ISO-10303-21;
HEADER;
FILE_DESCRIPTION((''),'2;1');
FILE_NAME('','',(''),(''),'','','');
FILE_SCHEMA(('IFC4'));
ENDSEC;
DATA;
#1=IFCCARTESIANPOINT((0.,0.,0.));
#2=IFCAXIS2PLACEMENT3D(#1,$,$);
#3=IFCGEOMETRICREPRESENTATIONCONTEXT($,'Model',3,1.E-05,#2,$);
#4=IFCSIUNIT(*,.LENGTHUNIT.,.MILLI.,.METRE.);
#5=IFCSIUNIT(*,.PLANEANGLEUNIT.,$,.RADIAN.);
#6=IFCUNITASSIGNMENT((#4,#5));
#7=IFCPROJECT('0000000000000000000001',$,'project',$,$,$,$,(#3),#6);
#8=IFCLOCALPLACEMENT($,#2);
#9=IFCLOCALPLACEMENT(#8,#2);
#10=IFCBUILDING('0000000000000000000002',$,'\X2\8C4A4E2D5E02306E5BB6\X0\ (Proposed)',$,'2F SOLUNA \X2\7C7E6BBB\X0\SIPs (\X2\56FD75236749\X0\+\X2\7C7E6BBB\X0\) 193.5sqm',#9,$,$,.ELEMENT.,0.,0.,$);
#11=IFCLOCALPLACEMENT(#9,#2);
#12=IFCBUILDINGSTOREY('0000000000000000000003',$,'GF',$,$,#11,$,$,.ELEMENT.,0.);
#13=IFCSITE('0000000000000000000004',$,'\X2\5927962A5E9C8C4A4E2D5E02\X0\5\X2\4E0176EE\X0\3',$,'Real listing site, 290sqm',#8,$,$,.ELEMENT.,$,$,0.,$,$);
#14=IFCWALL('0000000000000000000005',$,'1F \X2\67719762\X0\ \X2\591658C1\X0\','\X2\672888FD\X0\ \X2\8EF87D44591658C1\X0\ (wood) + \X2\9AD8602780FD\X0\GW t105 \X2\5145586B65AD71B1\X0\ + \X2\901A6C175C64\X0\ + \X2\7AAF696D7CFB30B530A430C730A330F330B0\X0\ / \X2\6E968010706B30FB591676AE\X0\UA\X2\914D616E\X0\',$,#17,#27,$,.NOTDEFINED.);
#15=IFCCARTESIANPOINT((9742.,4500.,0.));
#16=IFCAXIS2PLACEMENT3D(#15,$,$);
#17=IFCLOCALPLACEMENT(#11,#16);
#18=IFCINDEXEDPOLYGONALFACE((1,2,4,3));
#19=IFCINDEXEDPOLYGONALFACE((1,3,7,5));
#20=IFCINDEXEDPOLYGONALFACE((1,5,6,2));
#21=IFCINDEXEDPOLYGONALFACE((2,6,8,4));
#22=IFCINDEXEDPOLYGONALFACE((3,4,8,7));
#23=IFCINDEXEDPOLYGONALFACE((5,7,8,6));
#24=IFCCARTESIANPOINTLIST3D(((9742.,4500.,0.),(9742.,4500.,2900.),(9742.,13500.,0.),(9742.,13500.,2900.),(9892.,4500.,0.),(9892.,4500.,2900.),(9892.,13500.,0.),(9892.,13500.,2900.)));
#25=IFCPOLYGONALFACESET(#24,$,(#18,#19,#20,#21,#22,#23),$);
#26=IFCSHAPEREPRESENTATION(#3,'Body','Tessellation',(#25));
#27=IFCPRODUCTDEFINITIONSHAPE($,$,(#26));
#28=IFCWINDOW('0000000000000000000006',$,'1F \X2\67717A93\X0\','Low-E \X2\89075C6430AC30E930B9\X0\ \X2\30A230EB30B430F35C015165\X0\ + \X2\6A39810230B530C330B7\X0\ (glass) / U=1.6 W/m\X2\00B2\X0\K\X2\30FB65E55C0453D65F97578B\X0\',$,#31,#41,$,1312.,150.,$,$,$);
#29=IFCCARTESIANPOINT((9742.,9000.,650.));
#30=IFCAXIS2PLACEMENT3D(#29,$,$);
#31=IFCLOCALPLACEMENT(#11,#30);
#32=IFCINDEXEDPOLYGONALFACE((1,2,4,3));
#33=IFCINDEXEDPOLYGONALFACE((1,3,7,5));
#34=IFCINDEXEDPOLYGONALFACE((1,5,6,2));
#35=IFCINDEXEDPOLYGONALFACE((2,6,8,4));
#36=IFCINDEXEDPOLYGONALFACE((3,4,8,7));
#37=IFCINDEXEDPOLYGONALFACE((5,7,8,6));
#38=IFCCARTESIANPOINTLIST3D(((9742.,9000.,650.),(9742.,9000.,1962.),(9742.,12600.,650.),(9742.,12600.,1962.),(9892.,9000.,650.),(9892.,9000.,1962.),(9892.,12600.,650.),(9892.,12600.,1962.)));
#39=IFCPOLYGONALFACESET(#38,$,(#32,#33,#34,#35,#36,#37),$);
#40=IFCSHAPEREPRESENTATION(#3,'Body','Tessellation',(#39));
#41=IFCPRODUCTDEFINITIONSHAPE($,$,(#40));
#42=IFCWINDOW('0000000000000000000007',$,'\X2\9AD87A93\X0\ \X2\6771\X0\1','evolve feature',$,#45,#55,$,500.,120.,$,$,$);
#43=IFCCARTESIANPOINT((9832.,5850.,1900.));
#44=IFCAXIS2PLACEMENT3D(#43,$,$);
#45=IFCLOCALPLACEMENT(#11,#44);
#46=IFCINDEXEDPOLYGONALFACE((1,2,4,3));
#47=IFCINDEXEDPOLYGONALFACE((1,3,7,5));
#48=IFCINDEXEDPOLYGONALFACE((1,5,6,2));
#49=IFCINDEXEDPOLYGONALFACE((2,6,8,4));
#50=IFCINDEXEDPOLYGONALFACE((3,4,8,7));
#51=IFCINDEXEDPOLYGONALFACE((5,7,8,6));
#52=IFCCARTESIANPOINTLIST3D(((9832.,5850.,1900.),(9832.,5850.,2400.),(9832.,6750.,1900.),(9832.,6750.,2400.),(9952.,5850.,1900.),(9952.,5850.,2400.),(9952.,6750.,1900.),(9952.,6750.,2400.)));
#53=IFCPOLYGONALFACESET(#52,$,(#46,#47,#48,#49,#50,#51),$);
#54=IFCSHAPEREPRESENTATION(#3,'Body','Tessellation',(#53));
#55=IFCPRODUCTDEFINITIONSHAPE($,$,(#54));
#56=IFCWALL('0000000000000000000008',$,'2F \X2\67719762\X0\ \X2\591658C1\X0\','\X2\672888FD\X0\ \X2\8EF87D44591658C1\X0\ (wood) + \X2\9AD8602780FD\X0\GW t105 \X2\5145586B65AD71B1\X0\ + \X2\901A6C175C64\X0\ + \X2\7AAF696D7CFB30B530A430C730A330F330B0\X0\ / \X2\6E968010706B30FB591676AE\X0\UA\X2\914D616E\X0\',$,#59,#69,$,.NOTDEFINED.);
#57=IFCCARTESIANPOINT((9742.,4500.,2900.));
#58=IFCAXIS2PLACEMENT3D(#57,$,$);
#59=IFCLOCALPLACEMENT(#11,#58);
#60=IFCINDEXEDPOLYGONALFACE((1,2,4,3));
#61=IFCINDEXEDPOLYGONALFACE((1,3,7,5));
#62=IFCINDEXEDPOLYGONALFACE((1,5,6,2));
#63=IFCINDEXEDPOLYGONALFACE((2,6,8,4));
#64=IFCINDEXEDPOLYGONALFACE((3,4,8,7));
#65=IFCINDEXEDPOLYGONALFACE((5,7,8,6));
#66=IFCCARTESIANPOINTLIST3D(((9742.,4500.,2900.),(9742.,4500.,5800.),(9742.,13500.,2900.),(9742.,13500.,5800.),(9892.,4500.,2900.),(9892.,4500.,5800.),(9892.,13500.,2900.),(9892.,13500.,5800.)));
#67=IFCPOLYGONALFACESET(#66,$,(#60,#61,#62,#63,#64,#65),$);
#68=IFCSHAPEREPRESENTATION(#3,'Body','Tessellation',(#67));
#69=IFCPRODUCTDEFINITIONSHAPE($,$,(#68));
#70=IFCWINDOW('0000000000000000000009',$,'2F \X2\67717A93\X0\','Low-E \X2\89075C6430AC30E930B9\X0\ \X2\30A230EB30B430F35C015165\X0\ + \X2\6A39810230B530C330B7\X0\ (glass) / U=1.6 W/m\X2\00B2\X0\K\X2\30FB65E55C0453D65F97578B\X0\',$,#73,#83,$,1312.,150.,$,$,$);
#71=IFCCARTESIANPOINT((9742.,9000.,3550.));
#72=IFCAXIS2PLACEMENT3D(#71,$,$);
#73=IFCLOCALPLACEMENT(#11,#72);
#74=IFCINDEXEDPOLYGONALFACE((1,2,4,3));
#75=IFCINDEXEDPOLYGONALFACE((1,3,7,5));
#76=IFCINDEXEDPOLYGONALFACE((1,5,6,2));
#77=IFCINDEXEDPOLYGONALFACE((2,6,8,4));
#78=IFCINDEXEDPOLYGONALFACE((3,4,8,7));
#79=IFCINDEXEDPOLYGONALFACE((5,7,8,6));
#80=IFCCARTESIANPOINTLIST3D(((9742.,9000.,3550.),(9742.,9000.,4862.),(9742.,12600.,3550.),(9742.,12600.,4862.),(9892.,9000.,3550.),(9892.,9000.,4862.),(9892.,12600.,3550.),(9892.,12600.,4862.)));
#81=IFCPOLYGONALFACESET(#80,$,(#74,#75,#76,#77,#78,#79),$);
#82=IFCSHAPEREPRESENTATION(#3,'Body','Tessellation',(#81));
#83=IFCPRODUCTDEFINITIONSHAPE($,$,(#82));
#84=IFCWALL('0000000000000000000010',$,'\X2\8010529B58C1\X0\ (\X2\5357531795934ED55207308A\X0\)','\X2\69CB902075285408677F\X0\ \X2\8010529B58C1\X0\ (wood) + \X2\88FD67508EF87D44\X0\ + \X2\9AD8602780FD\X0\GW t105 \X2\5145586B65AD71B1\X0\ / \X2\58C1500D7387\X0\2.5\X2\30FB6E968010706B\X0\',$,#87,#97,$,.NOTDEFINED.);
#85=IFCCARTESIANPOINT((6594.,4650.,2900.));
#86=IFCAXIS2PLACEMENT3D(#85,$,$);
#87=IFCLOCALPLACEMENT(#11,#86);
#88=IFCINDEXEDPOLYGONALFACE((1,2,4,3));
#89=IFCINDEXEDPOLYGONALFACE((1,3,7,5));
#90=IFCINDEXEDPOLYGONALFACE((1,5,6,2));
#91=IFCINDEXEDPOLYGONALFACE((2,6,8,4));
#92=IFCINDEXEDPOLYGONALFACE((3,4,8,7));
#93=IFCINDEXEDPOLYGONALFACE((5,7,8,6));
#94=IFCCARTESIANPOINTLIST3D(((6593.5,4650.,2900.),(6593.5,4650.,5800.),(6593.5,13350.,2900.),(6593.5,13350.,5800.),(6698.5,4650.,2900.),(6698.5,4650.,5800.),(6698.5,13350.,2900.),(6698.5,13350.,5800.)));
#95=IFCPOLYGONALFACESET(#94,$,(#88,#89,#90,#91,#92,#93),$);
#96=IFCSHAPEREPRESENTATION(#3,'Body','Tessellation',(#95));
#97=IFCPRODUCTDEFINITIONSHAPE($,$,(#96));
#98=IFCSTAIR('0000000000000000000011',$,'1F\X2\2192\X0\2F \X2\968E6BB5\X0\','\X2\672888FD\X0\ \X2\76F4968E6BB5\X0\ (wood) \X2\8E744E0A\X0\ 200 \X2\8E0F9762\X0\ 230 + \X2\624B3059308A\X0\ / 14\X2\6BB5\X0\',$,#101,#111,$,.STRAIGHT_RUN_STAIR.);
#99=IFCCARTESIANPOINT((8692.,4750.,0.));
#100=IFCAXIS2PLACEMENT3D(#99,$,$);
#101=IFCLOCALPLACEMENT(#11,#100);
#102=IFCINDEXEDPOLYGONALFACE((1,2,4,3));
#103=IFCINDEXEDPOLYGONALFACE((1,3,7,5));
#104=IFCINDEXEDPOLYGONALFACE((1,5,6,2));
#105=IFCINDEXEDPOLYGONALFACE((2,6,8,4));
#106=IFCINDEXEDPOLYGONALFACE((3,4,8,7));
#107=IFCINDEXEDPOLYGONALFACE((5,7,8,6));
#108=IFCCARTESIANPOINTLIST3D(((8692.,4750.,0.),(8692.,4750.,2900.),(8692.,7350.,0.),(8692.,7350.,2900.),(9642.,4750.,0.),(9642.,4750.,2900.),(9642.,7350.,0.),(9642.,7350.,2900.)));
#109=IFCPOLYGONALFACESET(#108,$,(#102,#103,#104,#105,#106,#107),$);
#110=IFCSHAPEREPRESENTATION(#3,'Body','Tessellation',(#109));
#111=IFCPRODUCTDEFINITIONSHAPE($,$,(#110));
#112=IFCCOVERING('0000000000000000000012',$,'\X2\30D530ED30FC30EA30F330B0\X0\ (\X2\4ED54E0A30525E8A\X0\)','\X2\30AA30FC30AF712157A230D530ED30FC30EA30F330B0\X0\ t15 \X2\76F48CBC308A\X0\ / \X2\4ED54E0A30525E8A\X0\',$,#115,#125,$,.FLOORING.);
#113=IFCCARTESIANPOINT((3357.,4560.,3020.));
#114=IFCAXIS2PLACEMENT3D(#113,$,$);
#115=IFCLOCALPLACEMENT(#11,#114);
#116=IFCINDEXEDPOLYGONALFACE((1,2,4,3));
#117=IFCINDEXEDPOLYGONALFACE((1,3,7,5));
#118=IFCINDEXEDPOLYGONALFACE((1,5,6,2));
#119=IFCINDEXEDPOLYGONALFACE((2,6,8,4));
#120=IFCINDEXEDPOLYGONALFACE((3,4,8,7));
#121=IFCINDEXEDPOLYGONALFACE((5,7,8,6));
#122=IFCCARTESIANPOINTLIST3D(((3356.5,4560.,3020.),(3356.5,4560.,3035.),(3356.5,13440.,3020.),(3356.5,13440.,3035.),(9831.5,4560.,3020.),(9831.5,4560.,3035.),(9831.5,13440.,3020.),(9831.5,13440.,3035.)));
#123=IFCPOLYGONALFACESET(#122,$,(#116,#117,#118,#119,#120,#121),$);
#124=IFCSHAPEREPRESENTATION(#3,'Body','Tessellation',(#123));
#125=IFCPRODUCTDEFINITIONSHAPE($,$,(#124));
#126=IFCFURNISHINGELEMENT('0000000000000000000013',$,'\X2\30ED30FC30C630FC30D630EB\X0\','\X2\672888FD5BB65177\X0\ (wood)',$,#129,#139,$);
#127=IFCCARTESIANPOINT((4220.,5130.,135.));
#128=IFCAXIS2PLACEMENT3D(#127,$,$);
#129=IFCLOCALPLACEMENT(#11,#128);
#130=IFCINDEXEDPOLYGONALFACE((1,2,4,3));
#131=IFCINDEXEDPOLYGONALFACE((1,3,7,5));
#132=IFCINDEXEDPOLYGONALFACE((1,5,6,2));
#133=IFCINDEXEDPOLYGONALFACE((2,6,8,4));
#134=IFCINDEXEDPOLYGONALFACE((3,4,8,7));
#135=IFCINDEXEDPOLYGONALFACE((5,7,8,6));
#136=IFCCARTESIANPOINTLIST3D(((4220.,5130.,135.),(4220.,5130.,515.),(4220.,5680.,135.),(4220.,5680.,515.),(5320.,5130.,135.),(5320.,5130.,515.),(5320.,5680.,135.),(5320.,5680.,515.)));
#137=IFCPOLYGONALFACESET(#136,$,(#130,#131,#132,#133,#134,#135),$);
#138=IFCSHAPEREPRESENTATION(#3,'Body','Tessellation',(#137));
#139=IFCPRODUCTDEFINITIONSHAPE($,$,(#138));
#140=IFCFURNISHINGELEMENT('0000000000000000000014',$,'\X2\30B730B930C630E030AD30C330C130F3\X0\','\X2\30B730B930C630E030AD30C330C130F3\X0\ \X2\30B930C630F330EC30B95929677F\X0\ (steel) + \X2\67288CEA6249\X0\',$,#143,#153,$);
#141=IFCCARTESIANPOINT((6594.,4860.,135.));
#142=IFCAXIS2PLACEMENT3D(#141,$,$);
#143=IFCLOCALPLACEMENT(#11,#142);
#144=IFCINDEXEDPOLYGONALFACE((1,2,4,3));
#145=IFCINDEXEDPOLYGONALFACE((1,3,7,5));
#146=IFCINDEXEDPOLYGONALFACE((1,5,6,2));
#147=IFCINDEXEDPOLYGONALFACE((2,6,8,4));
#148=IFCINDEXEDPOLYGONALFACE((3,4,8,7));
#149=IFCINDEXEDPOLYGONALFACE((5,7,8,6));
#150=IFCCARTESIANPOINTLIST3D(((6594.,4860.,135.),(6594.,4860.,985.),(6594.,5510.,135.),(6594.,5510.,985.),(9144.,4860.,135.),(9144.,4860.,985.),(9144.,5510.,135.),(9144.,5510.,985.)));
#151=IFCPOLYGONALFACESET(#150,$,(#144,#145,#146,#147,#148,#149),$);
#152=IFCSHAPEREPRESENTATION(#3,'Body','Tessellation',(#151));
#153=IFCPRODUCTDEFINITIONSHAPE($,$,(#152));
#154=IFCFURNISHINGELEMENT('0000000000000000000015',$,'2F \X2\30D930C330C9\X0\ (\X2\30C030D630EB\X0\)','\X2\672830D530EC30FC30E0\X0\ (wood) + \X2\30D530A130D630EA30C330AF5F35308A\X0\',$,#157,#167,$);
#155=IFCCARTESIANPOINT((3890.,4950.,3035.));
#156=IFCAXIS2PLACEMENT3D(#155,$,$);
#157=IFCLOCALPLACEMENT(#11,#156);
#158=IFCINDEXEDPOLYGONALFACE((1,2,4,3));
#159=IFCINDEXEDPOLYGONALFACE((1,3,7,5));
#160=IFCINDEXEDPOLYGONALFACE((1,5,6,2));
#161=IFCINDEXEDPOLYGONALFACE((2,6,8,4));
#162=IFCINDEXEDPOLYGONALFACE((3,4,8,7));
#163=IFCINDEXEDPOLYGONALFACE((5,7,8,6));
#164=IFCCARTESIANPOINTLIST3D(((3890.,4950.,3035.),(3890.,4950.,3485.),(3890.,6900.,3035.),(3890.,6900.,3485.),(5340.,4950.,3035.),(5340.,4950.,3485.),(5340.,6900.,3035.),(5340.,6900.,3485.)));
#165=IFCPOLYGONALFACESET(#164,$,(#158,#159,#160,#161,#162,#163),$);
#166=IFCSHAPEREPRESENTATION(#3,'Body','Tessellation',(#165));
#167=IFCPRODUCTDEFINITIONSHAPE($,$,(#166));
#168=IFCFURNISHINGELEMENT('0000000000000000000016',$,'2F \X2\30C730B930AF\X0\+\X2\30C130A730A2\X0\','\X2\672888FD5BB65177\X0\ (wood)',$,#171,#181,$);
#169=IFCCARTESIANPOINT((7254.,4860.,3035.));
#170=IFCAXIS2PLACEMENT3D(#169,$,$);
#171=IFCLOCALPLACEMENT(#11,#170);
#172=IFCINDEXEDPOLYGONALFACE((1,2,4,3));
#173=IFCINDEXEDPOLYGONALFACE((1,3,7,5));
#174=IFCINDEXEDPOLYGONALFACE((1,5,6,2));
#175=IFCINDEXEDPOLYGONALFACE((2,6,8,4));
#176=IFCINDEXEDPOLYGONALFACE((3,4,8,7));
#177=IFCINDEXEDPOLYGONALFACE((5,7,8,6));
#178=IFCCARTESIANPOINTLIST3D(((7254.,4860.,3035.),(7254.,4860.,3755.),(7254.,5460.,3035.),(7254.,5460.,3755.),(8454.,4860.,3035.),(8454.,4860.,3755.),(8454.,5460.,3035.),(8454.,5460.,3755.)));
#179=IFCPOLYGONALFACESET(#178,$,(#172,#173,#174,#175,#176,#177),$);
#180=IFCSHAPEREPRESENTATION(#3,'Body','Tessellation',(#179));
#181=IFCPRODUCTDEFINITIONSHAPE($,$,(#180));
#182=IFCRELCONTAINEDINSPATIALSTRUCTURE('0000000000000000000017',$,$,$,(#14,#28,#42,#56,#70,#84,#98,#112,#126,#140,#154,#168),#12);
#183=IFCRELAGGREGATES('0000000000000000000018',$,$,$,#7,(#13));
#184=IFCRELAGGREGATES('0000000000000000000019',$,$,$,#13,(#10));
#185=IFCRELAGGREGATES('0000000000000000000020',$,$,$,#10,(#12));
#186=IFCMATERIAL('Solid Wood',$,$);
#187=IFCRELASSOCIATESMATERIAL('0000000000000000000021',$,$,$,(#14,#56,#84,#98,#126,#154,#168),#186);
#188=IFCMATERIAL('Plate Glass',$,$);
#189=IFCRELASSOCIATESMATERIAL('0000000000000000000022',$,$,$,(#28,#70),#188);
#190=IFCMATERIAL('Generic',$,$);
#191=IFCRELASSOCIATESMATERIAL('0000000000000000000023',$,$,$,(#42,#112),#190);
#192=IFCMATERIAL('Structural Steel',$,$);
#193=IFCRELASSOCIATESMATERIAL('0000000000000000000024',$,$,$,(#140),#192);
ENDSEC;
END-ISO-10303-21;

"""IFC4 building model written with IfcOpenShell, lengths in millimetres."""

from ifc_helpers import new_model, si_unit, frame, frame_2d, origin, place, context, project, spatial, rectangle, extrude, material, element, fill, save


model = new_model("IFC4")

# Units and contexts
model_context = context("Model", 3, precision=1e-05, world=origin())
ifc_project = project(units=[si_unit("LENGTHUNIT", "METRE", prefix="MILLI"), si_unit("PLANEANGLEUNIT", "RADIAN")], contexts=[model_context])

# Site, building, storey
site_placement = place(None, origin())
site = spatial("IfcSite", under=ifc_project, at=site_placement, Name="大阪府豊中市5丁目3", ObjectType="Real listing site, 290sqm", CompositionType="ELEMENT", RefElevation=0.0)
building_placement = place(site_placement, origin())
building = spatial("IfcBuilding", under=site, at=building_placement, Name="豊中市の家 (Proposed)", ObjectType="2F SOLUNA 籾殻SIPs (国産杉+籾殻) 193.5sqm", CompositionType="ELEMENT", ElevationOfRefHeight=0.0, ElevationOfTerrain=0.0)
storey_placement = place(building_placement, origin())
storey = spatial("IfcBuildingStorey", under=building, at=storey_placement, Name="GF", CompositionType="ELEMENT", Elevation=0.0)

# Shared definitions
ifc_material_1 = material(Name="Solid Wood")

# Wall, openings, windows
wall_1_placement = place(storey_placement, frame((9742.0, 4500.0, 0.0)))
wall_1 = element("IfcWall", 1, at=wall_1_placement, inside=storey, material=ifc_material_1, Name="1F 東面 外壁", Description="木製 軸組外壁 (wood) + 高性能GW t105 充填断熱 + 通気層 + 窯業系サイディング / 準耐火・外皮UA配慮", PredefinedType="NOTDEFINED", context=model_context, shape_type="SweptSolid", body=[
    extrude(rectangle(XDim=150.0, YDim=9000.0, at=frame_2d((75.0, 4500.0))), frame((9742.0, 4500.0, 0.0)), (0.0, 0.0, 1.0), 2900.0),
])
opening_1_placement = place(storey_placement, frame((9742.0, 9000.0, 650.0)))
opening_1 = element("IfcOpeningElement", 2, at=opening_1_placement, cuts=wall_1, PredefinedType="NOTDEFINED", context=model_context, shape_type="SweptSolid", body=[
    extrude(rectangle(XDim=150.0, YDim=3600.0, at=frame_2d((75.0, 1800.0))), frame((9742.0, 9000.0, 650.0)), (0.0, 0.0, 1.0), 1312.0),
])
opening_2_placement = place(storey_placement, frame((9832.0, 5850.0, 1900.0)))
opening_2 = element("IfcOpeningElement", 3, at=opening_2_placement, cuts=wall_1, PredefinedType="NOTDEFINED", context=model_context, shape_type="SweptSolid", body=[
    extrude(rectangle(XDim=120.0, YDim=900.0, at=frame_2d((60.0, 450.0))), frame((9832.0, 5850.0, 1900.0)), (0.0, 0.0, 1.0), 500.0),
])
ifc_material_2 = material(Name="Plate Glass")
window_1_placement = place(storey_placement, frame((9742.0, 9000.0, 650.0)))
window_1 = element("IfcWindow", 4, at=window_1_placement, inside=storey, material=ifc_material_2, Name="1F 東窓", Description="Low-E 複層ガラス アルゴン封入 + 樹脂サッシ (glass) / U=1.6 W/m²K・日射取得型", OverallHeight=1312.0, OverallWidth=150.0, context=model_context, shape_type="SweptSolid", body=[
    extrude(rectangle(XDim=150.0, YDim=3600.0, at=frame_2d((75.0, 1800.0))), frame((9742.0, 9000.0, 650.0)), (0.0, 0.0, 1.0), 1312.0),
])
fill(opening_1, window_1)
ifc_material_3 = material(Name="Generic")
window_2_placement = place(storey_placement, frame((9832.0, 5850.0, 1900.0)))
window_2 = element("IfcWindow", 5, at=window_2_placement, inside=storey, material=ifc_material_3, Name="高窓 東1", Description="evolve feature", OverallHeight=500.0, OverallWidth=120.0, context=model_context, shape_type="SweptSolid", body=[
    extrude(rectangle(XDim=120.0, YDim=900.0, at=frame_2d((60.0, 450.0))), frame((9832.0, 5850.0, 1900.0)), (0.0, 0.0, 1.0), 500.0),
])
fill(opening_2, window_2)

# Wall, opening, window
wall_2_placement = place(storey_placement, frame((9742.0, 4500.0, 2900.0)))
wall_2 = element("IfcWall", 6, at=wall_2_placement, inside=storey, material=ifc_material_1, Name="2F 東面 外壁", Description="木製 軸組外壁 (wood) + 高性能GW t105 充填断熱 + 通気層 + 窯業系サイディング / 準耐火・外皮UA配慮", PredefinedType="NOTDEFINED", context=model_context, shape_type="SweptSolid", body=[
    extrude(rectangle(XDim=150.0, YDim=9000.0, at=frame_2d((75.0, 4500.0))), frame((9742.0, 4500.0, 2900.0)), (0.0, 0.0, 1.0), 2900.0),
])
opening_3_placement = place(storey_placement, frame((9742.0, 9000.0, 3550.0)))
opening_3 = element("IfcOpeningElement", 7, at=opening_3_placement, cuts=wall_2, PredefinedType="NOTDEFINED", context=model_context, shape_type="SweptSolid", body=[
    extrude(rectangle(XDim=150.0, YDim=3600.0, at=frame_2d((75.0, 1800.0))), frame((9742.0, 9000.0, 3550.0)), (0.0, 0.0, 1.0), 1312.0),
])
window_3_placement = place(storey_placement, frame((9742.0, 9000.0, 3550.0)))
window_3 = element("IfcWindow", 8, at=window_3_placement, inside=storey, material=ifc_material_2, Name="2F 東窓", Description="Low-E 複層ガラス アルゴン封入 + 樹脂サッシ (glass) / U=1.6 W/m²K・日射取得型", OverallHeight=1312.0, OverallWidth=150.0, context=model_context, shape_type="SweptSolid", body=[
    extrude(rectangle(XDim=150.0, YDim=3600.0, at=frame_2d((75.0, 1800.0))), frame((9742.0, 9000.0, 3550.0)), (0.0, 0.0, 1.0), 1312.0),
])
fill(opening_3, window_3)

# Wall
wall_3_placement = place(storey_placement, frame((6594.0, 4650.0, 2900.0)))
element("IfcWall", 9, at=wall_3_placement, inside=storey, material=ifc_material_1, Name="耐力壁 (南北間仕切り)", Description="構造用合板 耐力壁 (wood) + 製材軸組 + 高性能GW t105 充填断熱 / 壁倍率2.5・準耐火", PredefinedType="NOTDEFINED", context=model_context, shape_type="SweptSolid", body=[
    extrude(rectangle(XDim=105.0, YDim=8700.0, at=frame_2d((52.0, 4350.0))), frame((6594.0, 4650.0, 2900.0)), (0.0, 0.0, 1.0), 2900.0),
])

# Stair
stair_placement = place(storey_placement, frame((8692.0, 4750.0, 0.0)))
element("IfcStair", 10, at=stair_placement, inside=storey, material=ifc_material_1, Name="1F→2F 階段", Description="木製 直階段 (wood) 蹴上 200 踏面 230 + 手すり / 14段", PredefinedType="STRAIGHT_RUN_STAIR", context=model_context, shape_type="SweptSolid", body=[
    extrude(rectangle(XDim=950.0, YDim=2600.0, at=frame_2d((475.0, 1300.0))), frame((8692.0, 4750.0, 0.0)), (0.0, 0.0, 1.0), 2900.0),
])

# Covering
covering_placement = place(storey_placement, frame((3357.0, 4560.0, 3020.0)))
element("IfcCovering", 11, at=covering_placement, inside=storey, material=ifc_material_3, Name="フローリング (仕上げ床)", Description="オーク無垢フローリング t15 直貼り / 仕上げ床", PredefinedType="FLOORING", context=model_context, shape_type="SweptSolid", body=[
    extrude(rectangle(XDim=6475.0, YDim=8880.0, at=frame_2d((3237.0, 4440.0))), frame((3357.0, 4560.0, 3020.0)), (0.0, 0.0, 1.0), 15.0),
])

# Furnishing elements
furnishing_1_placement = place(storey_placement, frame((4220.0, 5130.0, 135.0)))
element("IfcFurnishingElement", 12, at=furnishing_1_placement, inside=storey, material=ifc_material_1, Name="ローテーブル", Description="木製家具 (wood)", context=model_context, shape_type="SweptSolid", body=[
    extrude(rectangle(XDim=1100.0, YDim=550.0, at=frame_2d((550.0, 275.0))), frame((4220.0, 5130.0, 135.0)), (0.0, 0.0, 1.0), 380.0),
])
ifc_material_4 = material(Name="Structural Steel")
furnishing_2_placement = place(storey_placement, frame((6594.0, 4860.0, 135.0)))
element("IfcFurnishingElement", 13, at=furnishing_2_placement, inside=storey, material=ifc_material_4, Name="システムキッチン", Description="システムキッチン ステンレス天板 (steel) + 木質扉", context=model_context, shape_type="SweptSolid", body=[
    extrude(rectangle(XDim=2550.0, YDim=650.0, at=frame_2d((1275.0, 325.0))), frame((6594.0, 4860.0, 135.0)), (0.0, 0.0, 1.0), 850.0),
])
furnishing_3_placement = place(storey_placement, frame((3890.0, 4950.0, 3035.0)))
element("IfcFurnishingElement", 14, at=furnishing_3_placement, inside=storey, material=ifc_material_1, Name="2F ベッド (ダブル)", Description="木フレーム (wood) + ファブリック張り", context=model_context, shape_type="SweptSolid", body=[
    extrude(rectangle(XDim=1450.0, YDim=1950.0, at=frame_2d((725.0, 975.0))), frame((3890.0, 4950.0, 3035.0)), (0.0, 0.0, 1.0), 450.0),
])
furnishing_4_placement = place(storey_placement, frame((7254.0, 4860.0, 3035.0)))
element("IfcFurnishingElement", 15, at=furnishing_4_placement, inside=storey, material=ifc_material_1, Name="2F デスク+チェア", Description="木製家具 (wood)", context=model_context, shape_type="SweptSolid", body=[
    extrude(rectangle(XDim=1200.0, YDim=600.0, at=frame_2d((600.0, 300.0))), frame((7254.0, 4860.0, 3035.0)), (0.0, 0.0, 1.0), 720.0),
])

save(model, "model.ifc")
